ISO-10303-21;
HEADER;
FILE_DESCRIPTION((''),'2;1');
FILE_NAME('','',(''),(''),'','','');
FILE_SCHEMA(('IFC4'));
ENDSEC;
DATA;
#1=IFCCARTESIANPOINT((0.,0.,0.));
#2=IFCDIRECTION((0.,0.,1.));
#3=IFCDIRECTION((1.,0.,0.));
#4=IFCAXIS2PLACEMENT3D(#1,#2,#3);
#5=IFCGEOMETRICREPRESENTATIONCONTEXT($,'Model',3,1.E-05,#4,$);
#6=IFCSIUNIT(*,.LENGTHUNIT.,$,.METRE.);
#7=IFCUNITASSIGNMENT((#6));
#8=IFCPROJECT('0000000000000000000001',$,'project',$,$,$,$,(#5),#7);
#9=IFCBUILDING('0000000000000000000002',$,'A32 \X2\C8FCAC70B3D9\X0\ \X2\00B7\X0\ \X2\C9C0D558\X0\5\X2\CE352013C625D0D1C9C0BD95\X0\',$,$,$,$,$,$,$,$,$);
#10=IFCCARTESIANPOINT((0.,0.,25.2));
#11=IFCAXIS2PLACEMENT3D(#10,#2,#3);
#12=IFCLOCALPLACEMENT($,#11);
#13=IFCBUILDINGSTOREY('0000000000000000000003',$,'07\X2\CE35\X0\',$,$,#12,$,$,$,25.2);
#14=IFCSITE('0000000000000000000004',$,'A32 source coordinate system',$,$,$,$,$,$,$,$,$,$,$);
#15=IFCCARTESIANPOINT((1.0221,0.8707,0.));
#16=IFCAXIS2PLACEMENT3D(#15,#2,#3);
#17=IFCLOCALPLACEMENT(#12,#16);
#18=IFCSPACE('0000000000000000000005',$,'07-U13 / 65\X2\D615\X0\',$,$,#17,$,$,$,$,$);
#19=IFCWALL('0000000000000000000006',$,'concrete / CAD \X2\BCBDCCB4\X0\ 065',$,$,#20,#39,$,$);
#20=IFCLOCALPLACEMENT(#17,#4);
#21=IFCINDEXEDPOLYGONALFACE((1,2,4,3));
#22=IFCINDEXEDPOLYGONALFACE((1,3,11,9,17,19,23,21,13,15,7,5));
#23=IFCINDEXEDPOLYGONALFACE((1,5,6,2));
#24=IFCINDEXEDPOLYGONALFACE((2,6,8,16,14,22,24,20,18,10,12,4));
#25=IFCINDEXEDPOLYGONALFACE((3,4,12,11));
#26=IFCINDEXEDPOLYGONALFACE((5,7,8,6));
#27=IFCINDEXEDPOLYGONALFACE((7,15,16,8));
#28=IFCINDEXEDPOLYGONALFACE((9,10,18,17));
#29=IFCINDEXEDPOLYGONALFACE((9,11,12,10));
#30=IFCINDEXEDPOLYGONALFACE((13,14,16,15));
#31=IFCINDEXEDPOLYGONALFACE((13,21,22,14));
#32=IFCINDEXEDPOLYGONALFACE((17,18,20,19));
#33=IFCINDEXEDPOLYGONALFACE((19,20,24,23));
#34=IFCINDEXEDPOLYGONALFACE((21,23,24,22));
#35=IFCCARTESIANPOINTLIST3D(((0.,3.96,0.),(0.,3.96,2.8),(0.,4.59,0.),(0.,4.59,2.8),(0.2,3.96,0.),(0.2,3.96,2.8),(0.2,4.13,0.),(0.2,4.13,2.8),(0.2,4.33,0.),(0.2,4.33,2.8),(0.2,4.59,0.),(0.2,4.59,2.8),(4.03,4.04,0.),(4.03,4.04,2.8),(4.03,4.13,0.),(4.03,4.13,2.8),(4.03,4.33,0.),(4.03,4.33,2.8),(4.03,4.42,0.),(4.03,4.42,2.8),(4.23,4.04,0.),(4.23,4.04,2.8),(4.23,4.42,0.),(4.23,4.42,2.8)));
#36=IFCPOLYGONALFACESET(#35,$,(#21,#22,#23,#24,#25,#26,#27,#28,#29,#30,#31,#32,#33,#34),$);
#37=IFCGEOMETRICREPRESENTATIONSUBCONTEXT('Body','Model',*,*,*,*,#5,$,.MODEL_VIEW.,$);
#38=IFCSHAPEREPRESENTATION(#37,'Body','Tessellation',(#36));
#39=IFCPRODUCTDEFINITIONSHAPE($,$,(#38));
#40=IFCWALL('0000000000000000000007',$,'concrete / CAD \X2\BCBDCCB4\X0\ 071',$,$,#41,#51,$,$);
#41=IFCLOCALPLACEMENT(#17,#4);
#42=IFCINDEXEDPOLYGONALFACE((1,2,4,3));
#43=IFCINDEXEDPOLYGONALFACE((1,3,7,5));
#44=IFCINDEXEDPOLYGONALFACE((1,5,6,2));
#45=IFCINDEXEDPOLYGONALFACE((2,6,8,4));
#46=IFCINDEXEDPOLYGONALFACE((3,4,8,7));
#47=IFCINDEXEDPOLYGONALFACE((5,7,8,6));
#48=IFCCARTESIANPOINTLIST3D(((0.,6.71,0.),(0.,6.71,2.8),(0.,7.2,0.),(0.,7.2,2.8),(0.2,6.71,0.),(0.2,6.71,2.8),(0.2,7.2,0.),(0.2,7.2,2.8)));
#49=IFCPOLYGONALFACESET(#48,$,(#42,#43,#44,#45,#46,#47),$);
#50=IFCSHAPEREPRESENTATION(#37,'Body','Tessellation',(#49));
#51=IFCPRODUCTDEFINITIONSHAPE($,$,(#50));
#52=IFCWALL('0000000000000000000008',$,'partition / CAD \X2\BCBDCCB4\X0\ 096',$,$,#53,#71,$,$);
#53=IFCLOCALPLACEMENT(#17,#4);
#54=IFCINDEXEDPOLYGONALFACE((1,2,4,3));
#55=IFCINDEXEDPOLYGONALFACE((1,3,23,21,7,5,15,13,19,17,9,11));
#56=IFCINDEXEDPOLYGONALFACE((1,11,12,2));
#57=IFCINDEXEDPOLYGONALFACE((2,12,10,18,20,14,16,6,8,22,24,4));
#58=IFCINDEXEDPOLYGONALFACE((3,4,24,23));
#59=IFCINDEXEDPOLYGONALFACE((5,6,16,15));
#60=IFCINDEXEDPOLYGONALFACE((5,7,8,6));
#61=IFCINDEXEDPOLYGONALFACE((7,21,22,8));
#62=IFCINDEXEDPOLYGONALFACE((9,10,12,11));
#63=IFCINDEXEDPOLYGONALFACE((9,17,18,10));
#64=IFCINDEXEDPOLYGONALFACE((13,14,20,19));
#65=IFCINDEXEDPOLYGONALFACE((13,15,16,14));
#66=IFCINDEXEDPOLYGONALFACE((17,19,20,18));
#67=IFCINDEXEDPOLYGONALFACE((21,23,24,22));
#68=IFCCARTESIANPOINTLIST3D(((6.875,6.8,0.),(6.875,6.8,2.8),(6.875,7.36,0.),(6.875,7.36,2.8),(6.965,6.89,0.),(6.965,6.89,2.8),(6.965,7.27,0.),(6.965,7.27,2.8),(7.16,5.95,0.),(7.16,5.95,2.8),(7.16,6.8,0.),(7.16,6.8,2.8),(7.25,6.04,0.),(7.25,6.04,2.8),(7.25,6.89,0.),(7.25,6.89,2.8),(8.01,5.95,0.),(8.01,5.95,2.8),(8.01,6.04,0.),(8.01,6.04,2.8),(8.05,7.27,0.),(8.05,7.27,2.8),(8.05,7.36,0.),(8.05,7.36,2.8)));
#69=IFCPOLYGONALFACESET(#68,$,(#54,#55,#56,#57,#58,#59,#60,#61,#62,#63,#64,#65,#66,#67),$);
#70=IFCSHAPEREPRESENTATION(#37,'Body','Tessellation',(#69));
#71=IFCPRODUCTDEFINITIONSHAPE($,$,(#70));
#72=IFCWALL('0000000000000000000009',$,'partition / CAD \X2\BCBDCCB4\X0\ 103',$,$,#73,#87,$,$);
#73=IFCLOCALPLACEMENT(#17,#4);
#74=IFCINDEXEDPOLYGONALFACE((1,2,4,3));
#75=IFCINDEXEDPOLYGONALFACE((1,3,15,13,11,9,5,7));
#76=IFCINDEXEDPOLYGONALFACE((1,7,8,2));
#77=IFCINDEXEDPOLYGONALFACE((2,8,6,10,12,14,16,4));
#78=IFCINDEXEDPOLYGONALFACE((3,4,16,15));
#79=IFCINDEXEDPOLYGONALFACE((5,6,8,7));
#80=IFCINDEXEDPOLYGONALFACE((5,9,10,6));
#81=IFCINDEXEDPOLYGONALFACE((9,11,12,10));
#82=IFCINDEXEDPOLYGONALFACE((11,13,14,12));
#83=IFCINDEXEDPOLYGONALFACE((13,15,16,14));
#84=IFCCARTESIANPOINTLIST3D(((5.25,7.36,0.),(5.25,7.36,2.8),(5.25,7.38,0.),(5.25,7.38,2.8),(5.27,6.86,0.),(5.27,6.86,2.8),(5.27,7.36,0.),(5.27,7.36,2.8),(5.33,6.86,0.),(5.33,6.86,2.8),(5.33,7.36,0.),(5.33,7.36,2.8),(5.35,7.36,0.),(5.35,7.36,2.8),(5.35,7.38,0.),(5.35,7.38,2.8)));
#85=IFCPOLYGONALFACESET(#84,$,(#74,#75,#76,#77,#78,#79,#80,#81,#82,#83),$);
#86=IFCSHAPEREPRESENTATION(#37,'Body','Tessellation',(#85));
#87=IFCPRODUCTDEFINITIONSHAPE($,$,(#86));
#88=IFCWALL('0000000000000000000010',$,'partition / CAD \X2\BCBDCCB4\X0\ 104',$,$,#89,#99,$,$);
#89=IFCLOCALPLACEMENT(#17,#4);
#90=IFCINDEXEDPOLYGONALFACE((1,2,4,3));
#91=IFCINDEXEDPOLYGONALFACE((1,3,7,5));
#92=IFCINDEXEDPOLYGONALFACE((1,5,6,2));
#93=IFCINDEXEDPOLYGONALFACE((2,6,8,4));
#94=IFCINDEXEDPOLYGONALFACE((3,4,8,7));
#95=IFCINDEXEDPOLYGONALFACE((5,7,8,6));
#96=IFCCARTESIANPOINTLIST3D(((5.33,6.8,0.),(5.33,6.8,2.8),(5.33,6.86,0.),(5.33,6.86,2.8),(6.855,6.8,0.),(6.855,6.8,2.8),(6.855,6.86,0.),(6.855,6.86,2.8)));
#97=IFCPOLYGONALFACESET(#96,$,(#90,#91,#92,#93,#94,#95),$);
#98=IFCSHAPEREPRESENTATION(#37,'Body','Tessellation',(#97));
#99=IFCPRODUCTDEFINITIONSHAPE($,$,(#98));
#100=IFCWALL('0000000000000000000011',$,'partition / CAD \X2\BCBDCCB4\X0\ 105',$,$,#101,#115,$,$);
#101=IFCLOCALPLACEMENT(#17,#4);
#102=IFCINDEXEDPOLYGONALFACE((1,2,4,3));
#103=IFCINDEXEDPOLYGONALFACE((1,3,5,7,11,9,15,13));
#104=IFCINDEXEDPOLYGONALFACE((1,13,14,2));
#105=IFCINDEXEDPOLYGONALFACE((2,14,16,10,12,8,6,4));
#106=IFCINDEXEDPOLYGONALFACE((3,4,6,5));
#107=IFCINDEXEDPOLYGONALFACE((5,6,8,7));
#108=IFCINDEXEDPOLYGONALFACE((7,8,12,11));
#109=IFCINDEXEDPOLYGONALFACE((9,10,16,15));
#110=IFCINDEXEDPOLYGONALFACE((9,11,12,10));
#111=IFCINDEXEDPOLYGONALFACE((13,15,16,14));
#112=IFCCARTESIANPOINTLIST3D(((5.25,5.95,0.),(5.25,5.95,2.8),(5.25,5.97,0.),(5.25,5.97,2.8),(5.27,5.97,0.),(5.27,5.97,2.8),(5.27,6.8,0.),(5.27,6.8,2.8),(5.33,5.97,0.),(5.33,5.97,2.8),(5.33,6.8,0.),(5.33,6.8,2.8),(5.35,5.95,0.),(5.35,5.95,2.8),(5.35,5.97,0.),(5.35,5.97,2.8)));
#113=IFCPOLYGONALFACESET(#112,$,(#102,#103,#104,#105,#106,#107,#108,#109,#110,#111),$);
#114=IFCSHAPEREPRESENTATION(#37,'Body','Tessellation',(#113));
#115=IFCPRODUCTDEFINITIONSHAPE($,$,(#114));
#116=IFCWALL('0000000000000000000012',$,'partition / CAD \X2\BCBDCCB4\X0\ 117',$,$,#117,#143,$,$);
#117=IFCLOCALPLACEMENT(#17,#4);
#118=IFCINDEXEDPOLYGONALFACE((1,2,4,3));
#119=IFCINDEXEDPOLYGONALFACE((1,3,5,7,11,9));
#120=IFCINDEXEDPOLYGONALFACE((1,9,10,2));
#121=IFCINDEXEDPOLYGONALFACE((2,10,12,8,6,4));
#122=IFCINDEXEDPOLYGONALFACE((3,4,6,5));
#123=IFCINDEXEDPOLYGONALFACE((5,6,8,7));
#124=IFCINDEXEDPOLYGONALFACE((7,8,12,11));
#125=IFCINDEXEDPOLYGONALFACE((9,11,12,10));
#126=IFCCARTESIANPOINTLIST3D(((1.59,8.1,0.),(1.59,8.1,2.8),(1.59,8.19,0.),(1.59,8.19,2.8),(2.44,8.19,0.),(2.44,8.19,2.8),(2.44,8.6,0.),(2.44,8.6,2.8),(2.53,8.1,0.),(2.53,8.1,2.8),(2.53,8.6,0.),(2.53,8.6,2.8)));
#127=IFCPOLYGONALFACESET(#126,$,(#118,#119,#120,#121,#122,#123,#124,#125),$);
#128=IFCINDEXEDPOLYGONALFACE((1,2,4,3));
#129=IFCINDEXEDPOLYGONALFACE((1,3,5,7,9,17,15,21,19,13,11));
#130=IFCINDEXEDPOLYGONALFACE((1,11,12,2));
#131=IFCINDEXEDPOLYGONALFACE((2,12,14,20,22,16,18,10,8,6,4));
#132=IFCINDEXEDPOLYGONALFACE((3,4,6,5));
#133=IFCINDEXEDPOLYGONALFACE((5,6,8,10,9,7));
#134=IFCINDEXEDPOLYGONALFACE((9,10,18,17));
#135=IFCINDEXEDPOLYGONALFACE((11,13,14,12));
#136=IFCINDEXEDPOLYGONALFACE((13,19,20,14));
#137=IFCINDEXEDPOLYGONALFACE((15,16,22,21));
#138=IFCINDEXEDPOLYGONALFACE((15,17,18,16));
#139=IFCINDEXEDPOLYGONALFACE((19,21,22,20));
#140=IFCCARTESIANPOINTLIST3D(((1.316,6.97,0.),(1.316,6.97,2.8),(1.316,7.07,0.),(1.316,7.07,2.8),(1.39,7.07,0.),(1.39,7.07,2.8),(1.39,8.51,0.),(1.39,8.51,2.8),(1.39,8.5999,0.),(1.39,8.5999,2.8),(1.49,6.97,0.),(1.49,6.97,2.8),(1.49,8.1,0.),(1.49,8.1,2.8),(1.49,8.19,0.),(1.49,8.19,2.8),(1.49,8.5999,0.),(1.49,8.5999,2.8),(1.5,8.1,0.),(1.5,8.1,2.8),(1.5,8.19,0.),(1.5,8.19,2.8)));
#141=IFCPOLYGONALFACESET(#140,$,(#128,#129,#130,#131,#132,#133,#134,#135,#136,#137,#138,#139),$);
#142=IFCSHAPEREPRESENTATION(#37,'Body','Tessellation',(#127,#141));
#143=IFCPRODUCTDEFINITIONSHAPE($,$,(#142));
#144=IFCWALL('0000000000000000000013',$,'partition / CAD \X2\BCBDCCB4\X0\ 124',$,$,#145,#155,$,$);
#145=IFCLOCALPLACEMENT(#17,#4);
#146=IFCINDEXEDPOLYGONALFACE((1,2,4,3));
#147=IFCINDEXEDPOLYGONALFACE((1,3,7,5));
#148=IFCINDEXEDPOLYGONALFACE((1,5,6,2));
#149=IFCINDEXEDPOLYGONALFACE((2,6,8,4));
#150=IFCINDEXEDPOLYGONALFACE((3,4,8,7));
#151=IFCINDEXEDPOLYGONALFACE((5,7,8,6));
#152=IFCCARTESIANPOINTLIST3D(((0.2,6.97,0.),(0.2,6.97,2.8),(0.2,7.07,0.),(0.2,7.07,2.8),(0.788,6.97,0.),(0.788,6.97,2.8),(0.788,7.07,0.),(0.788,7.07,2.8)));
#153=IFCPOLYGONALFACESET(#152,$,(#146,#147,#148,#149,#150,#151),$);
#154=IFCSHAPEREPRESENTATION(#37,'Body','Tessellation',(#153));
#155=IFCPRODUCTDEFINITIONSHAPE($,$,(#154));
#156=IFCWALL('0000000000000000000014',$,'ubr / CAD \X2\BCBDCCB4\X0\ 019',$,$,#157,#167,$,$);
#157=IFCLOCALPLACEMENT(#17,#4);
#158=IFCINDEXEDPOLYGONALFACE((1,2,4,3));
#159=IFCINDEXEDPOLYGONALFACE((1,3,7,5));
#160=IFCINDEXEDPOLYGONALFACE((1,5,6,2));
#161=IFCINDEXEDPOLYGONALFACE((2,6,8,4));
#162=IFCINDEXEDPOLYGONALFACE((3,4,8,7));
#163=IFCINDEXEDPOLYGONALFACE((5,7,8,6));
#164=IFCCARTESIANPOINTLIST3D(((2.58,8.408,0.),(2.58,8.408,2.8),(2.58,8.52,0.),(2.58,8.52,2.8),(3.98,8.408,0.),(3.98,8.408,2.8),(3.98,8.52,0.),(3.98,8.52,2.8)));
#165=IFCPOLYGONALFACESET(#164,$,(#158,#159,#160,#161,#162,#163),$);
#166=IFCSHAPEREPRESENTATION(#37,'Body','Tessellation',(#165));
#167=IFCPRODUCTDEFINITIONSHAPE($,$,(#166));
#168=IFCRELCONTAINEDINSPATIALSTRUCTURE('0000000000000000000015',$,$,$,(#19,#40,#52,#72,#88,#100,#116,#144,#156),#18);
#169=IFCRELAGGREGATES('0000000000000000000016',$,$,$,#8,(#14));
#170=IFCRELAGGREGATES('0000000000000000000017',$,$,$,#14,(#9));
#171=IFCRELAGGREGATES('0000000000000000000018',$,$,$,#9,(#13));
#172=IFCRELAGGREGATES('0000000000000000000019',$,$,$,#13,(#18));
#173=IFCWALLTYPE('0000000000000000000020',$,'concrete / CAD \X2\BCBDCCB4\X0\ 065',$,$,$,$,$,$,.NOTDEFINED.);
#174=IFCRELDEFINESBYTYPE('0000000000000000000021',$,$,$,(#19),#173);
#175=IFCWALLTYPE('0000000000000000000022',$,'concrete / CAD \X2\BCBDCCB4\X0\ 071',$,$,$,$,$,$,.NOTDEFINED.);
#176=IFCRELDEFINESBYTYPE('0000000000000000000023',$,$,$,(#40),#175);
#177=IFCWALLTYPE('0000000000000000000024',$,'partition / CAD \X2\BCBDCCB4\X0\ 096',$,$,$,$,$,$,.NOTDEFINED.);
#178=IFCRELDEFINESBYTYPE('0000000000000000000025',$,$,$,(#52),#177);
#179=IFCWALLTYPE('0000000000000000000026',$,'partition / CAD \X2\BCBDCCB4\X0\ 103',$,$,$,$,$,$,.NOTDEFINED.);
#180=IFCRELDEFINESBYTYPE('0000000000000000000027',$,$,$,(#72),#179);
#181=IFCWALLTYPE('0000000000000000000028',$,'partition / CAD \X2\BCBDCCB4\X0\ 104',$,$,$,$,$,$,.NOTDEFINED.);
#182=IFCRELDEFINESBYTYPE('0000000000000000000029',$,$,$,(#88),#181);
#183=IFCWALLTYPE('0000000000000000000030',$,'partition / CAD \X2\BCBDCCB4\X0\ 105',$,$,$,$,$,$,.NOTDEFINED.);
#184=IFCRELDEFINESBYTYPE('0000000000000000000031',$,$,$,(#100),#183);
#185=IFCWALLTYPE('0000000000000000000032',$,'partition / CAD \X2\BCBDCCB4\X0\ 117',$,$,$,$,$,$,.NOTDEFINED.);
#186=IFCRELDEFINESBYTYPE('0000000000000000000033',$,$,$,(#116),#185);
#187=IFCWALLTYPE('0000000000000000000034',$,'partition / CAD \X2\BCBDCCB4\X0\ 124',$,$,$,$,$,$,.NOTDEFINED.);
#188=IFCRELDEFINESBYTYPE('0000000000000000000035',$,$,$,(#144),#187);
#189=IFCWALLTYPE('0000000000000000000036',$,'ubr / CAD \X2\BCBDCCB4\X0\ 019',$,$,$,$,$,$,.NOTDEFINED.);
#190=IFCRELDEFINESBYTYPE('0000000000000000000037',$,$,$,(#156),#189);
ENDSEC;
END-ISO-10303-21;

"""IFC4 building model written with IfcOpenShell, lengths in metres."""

from ifc_helpers import new_model, si_unit, frame, origin, origin_with_axes, place, context, subcontext, project, spatial, polyline, outline, extrude, source, transform, mapped, type_object, type_shapes, element, save


model = new_model("IFC4")

# Units and contexts
model_context = context("Model", 3, precision=1e-05, world=origin_with_axes())
body_context = subcontext(model_context, "Body", "Model", "MODEL_VIEW")
ifc_project = project(units=[si_unit("LENGTHUNIT", "METRE")], contexts=[model_context])

# Site, building, storey, space
storey_placement = place(None, frame((0.0, 0.0, 25.2), z_axis=(0.0, 0.0, 1.0), x_axis=(1.0, 0.0, 0.0)))
space_placement = place(storey_placement, frame((1.0221, 0.8707, 0.0), z_axis=(0.0, 0.0, 1.0), x_axis=(1.0, 0.0, 0.0)))
site = spatial("IfcSite", under=ifc_project, Name="A32 source coordinate system")
building = spatial("IfcBuilding", under=site, Name="A32 주거동 · 지하5층–옥탑지붕")
storey = spatial("IfcBuildingStorey", under=building, at=storey_placement, Name="07층", Elevation=25.2)
space = spatial("IfcSpace", under=storey, at=space_placement, Name="07-U13 / 65형")

# Walls
wall_type_1 = type_object("IfcWallType", Name="concrete / CAD 벽체 065", PredefinedType="NOTDEFINED")
shared_shape_1 = source(origin(), body_context, "Body", "SweptSolid", [
    extrude(outline(polyline([(0.2, 4.59), (0.2, 4.33), (4.03, 4.33), (4.03, 4.42), (4.23, 4.42), (4.23, 4.04), (4.03, 4.04), (4.03, 4.13), (0.2, 4.13), (0.2, 3.96), (0.0, 3.96), (0.0, 4.59), (0.2, 4.59)])), origin(), (0.0, 0.0, 1.0), 2.8),
])
type_shapes(wall_type_1, [shared_shape_1])
wall_1_placement = place(space_placement, origin_with_axes())
element("IfcWall", 1, at=wall_1_placement, inside=space, type_object=wall_type_1, Name="concrete / CAD 벽체 065", context=body_context, shape_type="MappedRepresentation", body=[
    mapped(shared_shape_1, transform((0.0, 0.0, 0.0), scale=1.0)),
])
wall_type_2 = type_object("IfcWallType", Name="concrete / CAD 벽체 071", PredefinedType="NOTDEFINED")
shared_shape_2 = source(origin(), body_context, "Body", "SweptSolid", [
    extrude(outline(polyline([(0.2, 6.71), (0.0, 6.71), (0.0, 7.2), (0.2, 7.2), (0.2, 6.71)])), origin(), (0.0, 0.0, 1.0), 2.8),
])
type_shapes(wall_type_2, [shared_shape_2])
wall_2_placement = place(space_placement, origin_with_axes())
element("IfcWall", 2, at=wall_2_placement, inside=space, type_object=wall_type_2, Name="concrete / CAD 벽체 071", context=body_context, shape_type="MappedRepresentation", body=[
    mapped(shared_shape_2, transform((0.0, 0.0, 0.0), scale=1.0)),
])
wall_type_3 = type_object("IfcWallType", Name="partition / CAD 벽체 096", PredefinedType="NOTDEFINED")
shared_shape_3 = source(origin(), body_context, "Body", "SweptSolid", [
    extrude(outline(polyline([(7.25, 6.04), (8.01, 6.04), (8.01, 5.95), (7.16, 5.95), (7.16, 6.8), (6.875, 6.8), (6.875, 7.36), (8.05, 7.36), (8.05, 7.27), (6.965, 7.27), (6.965, 6.89), (7.25, 6.89), (7.25, 6.04)])), origin(), (0.0, 0.0, 1.0), 2.8),
])
type_shapes(wall_type_3, [shared_shape_3])
wall_3_placement = place(space_placement, origin_with_axes())
element("IfcWall", 3, at=wall_3_placement, inside=space, type_object=wall_type_3, Name="partition / CAD 벽체 096", context=body_context, shape_type="MappedRepresentation", body=[
    mapped(shared_shape_3, transform((0.0, 0.0, 0.0), scale=1.0)),
])
wall_type_4 = type_object("IfcWallType", Name="partition / CAD 벽체 103", PredefinedType="NOTDEFINED")
shared_shape_4 = source(origin(), body_context, "Body", "SweptSolid", [
    extrude(outline(polyline([(5.27, 7.36), (5.25, 7.36), (5.25, 7.38), (5.35, 7.38), (5.35, 7.36), (5.33, 7.36), (5.33, 6.86), (5.27, 6.86), (5.27, 7.36)])), origin(), (0.0, 0.0, 1.0), 2.8),
])
type_shapes(wall_type_4, [shared_shape_4])
wall_4_placement = place(space_placement, origin_with_axes())
element("IfcWall", 4, at=wall_4_placement, inside=space, type_object=wall_type_4, Name="partition / CAD 벽체 103", context=body_context, shape_type="MappedRepresentation", body=[
    mapped(shared_shape_4, transform((0.0, 0.0, 0.0), scale=1.0)),
])
wall_type_5 = type_object("IfcWallType", Name="partition / CAD 벽체 104", PredefinedType="NOTDEFINED")
shared_shape_5 = source(origin(), body_context, "Body", "SweptSolid", [
    extrude(outline(polyline([(6.855, 6.86), (6.855, 6.8), (5.33, 6.8), (5.33, 6.86), (6.855, 6.86)])), origin(), (0.0, 0.0, 1.0), 2.8),
])
type_shapes(wall_type_5, [shared_shape_5])
wall_5_placement = place(space_placement, origin_with_axes())
element("IfcWall", 5, at=wall_5_placement, inside=space, type_object=wall_type_5, Name="partition / CAD 벽체 104", context=body_context, shape_type="MappedRepresentation", body=[
    mapped(shared_shape_5, transform((0.0, 0.0, 0.0), scale=1.0)),
])
wall_type_6 = type_object("IfcWallType", Name="partition / CAD 벽체 105", PredefinedType="NOTDEFINED")
shared_shape_6 = source(origin(), body_context, "Body", "SweptSolid", [
    extrude(outline(polyline([(5.25, 5.97), (5.27, 5.97), (5.27, 6.8), (5.33, 6.8), (5.33, 5.97), (5.35, 5.97), (5.35, 5.95), (5.25, 5.95), (5.25, 5.97)])), origin(), (0.0, 0.0, 1.0), 2.8),
])
type_shapes(wall_type_6, [shared_shape_6])
wall_6_placement = place(space_placement, origin_with_axes())
element("IfcWall", 6, at=wall_6_placement, inside=space, type_object=wall_type_6, Name="partition / CAD 벽체 105", context=body_context, shape_type="MappedRepresentation", body=[
    mapped(shared_shape_6, transform((0.0, 0.0, 0.0), scale=1.0)),
])
wall_type_7 = type_object("IfcWallType", Name="partition / CAD 벽체 117", PredefinedType="NOTDEFINED")
shared_shape_7 = source(origin(), body_context, "Body", "SweptSolid", [
    extrude(outline(polyline([(2.53, 8.1), (1.59, 8.1), (1.59, 8.19), (2.44, 8.19), (2.44, 8.6), (2.53, 8.6), (2.53, 8.1)])), origin(), (0.0, 0.0, 1.0), 2.8),
    extrude(outline(polyline([(1.49, 8.1), (1.49, 6.97), (1.316, 6.97), (1.316, 7.07), (1.39, 7.07), (1.39, 8.51), (1.39, 8.5999), (1.49, 8.5999), (1.49, 8.19), (1.5, 8.19), (1.5, 8.1), (1.49, 8.1)])), origin(), (0.0, 0.0, 1.0), 2.8),
])
type_shapes(wall_type_7, [shared_shape_7])
wall_7_placement = place(space_placement, origin_with_axes())
element("IfcWall", 7, at=wall_7_placement, inside=space, type_object=wall_type_7, Name="partition / CAD 벽체 117", context=body_context, shape_type="MappedRepresentation", body=[
    mapped(shared_shape_7, transform((0.0, 0.0, 0.0), scale=1.0)),
])
wall_type_8 = type_object("IfcWallType", Name="partition / CAD 벽체 124", PredefinedType="NOTDEFINED")
shared_shape_8 = source(origin(), body_context, "Body", "SweptSolid", [
    extrude(outline(polyline([(0.788, 7.07), (0.788, 6.97), (0.2, 6.97), (0.2, 7.07), (0.788, 7.07)])), origin(), (0.0, 0.0, 1.0), 2.8),
])
type_shapes(wall_type_8, [shared_shape_8])
wall_8_placement = place(space_placement, origin_with_axes())
element("IfcWall", 8, at=wall_8_placement, inside=space, type_object=wall_type_8, Name="partition / CAD 벽체 124", context=body_context, shape_type="MappedRepresentation", body=[
    mapped(shared_shape_8, transform((0.0, 0.0, 0.0), scale=1.0)),
])
wall_type_9 = type_object("IfcWallType", Name="ubr / CAD 벽체 019", PredefinedType="NOTDEFINED")
shared_shape_9 = source(origin(), body_context, "Body", "SweptSolid", [
    extrude(outline(polyline([(3.98, 8.408), (2.58, 8.408), (2.58, 8.52), (3.98, 8.52), (3.98, 8.408)])), origin(), (0.0, 0.0, 1.0), 2.8),
])
type_shapes(wall_type_9, [shared_shape_9])
wall_9_placement = place(space_placement, origin_with_axes())
element("IfcWall", 9, at=wall_9_placement, inside=space, type_object=wall_type_9, Name="ubr / CAD 벽체 019", context=body_context, shape_type="MappedRepresentation", body=[
    mapped(shared_shape_9, transform((0.0, 0.0, 0.0), scale=1.0)),
])

save(model, "model.ifc")
